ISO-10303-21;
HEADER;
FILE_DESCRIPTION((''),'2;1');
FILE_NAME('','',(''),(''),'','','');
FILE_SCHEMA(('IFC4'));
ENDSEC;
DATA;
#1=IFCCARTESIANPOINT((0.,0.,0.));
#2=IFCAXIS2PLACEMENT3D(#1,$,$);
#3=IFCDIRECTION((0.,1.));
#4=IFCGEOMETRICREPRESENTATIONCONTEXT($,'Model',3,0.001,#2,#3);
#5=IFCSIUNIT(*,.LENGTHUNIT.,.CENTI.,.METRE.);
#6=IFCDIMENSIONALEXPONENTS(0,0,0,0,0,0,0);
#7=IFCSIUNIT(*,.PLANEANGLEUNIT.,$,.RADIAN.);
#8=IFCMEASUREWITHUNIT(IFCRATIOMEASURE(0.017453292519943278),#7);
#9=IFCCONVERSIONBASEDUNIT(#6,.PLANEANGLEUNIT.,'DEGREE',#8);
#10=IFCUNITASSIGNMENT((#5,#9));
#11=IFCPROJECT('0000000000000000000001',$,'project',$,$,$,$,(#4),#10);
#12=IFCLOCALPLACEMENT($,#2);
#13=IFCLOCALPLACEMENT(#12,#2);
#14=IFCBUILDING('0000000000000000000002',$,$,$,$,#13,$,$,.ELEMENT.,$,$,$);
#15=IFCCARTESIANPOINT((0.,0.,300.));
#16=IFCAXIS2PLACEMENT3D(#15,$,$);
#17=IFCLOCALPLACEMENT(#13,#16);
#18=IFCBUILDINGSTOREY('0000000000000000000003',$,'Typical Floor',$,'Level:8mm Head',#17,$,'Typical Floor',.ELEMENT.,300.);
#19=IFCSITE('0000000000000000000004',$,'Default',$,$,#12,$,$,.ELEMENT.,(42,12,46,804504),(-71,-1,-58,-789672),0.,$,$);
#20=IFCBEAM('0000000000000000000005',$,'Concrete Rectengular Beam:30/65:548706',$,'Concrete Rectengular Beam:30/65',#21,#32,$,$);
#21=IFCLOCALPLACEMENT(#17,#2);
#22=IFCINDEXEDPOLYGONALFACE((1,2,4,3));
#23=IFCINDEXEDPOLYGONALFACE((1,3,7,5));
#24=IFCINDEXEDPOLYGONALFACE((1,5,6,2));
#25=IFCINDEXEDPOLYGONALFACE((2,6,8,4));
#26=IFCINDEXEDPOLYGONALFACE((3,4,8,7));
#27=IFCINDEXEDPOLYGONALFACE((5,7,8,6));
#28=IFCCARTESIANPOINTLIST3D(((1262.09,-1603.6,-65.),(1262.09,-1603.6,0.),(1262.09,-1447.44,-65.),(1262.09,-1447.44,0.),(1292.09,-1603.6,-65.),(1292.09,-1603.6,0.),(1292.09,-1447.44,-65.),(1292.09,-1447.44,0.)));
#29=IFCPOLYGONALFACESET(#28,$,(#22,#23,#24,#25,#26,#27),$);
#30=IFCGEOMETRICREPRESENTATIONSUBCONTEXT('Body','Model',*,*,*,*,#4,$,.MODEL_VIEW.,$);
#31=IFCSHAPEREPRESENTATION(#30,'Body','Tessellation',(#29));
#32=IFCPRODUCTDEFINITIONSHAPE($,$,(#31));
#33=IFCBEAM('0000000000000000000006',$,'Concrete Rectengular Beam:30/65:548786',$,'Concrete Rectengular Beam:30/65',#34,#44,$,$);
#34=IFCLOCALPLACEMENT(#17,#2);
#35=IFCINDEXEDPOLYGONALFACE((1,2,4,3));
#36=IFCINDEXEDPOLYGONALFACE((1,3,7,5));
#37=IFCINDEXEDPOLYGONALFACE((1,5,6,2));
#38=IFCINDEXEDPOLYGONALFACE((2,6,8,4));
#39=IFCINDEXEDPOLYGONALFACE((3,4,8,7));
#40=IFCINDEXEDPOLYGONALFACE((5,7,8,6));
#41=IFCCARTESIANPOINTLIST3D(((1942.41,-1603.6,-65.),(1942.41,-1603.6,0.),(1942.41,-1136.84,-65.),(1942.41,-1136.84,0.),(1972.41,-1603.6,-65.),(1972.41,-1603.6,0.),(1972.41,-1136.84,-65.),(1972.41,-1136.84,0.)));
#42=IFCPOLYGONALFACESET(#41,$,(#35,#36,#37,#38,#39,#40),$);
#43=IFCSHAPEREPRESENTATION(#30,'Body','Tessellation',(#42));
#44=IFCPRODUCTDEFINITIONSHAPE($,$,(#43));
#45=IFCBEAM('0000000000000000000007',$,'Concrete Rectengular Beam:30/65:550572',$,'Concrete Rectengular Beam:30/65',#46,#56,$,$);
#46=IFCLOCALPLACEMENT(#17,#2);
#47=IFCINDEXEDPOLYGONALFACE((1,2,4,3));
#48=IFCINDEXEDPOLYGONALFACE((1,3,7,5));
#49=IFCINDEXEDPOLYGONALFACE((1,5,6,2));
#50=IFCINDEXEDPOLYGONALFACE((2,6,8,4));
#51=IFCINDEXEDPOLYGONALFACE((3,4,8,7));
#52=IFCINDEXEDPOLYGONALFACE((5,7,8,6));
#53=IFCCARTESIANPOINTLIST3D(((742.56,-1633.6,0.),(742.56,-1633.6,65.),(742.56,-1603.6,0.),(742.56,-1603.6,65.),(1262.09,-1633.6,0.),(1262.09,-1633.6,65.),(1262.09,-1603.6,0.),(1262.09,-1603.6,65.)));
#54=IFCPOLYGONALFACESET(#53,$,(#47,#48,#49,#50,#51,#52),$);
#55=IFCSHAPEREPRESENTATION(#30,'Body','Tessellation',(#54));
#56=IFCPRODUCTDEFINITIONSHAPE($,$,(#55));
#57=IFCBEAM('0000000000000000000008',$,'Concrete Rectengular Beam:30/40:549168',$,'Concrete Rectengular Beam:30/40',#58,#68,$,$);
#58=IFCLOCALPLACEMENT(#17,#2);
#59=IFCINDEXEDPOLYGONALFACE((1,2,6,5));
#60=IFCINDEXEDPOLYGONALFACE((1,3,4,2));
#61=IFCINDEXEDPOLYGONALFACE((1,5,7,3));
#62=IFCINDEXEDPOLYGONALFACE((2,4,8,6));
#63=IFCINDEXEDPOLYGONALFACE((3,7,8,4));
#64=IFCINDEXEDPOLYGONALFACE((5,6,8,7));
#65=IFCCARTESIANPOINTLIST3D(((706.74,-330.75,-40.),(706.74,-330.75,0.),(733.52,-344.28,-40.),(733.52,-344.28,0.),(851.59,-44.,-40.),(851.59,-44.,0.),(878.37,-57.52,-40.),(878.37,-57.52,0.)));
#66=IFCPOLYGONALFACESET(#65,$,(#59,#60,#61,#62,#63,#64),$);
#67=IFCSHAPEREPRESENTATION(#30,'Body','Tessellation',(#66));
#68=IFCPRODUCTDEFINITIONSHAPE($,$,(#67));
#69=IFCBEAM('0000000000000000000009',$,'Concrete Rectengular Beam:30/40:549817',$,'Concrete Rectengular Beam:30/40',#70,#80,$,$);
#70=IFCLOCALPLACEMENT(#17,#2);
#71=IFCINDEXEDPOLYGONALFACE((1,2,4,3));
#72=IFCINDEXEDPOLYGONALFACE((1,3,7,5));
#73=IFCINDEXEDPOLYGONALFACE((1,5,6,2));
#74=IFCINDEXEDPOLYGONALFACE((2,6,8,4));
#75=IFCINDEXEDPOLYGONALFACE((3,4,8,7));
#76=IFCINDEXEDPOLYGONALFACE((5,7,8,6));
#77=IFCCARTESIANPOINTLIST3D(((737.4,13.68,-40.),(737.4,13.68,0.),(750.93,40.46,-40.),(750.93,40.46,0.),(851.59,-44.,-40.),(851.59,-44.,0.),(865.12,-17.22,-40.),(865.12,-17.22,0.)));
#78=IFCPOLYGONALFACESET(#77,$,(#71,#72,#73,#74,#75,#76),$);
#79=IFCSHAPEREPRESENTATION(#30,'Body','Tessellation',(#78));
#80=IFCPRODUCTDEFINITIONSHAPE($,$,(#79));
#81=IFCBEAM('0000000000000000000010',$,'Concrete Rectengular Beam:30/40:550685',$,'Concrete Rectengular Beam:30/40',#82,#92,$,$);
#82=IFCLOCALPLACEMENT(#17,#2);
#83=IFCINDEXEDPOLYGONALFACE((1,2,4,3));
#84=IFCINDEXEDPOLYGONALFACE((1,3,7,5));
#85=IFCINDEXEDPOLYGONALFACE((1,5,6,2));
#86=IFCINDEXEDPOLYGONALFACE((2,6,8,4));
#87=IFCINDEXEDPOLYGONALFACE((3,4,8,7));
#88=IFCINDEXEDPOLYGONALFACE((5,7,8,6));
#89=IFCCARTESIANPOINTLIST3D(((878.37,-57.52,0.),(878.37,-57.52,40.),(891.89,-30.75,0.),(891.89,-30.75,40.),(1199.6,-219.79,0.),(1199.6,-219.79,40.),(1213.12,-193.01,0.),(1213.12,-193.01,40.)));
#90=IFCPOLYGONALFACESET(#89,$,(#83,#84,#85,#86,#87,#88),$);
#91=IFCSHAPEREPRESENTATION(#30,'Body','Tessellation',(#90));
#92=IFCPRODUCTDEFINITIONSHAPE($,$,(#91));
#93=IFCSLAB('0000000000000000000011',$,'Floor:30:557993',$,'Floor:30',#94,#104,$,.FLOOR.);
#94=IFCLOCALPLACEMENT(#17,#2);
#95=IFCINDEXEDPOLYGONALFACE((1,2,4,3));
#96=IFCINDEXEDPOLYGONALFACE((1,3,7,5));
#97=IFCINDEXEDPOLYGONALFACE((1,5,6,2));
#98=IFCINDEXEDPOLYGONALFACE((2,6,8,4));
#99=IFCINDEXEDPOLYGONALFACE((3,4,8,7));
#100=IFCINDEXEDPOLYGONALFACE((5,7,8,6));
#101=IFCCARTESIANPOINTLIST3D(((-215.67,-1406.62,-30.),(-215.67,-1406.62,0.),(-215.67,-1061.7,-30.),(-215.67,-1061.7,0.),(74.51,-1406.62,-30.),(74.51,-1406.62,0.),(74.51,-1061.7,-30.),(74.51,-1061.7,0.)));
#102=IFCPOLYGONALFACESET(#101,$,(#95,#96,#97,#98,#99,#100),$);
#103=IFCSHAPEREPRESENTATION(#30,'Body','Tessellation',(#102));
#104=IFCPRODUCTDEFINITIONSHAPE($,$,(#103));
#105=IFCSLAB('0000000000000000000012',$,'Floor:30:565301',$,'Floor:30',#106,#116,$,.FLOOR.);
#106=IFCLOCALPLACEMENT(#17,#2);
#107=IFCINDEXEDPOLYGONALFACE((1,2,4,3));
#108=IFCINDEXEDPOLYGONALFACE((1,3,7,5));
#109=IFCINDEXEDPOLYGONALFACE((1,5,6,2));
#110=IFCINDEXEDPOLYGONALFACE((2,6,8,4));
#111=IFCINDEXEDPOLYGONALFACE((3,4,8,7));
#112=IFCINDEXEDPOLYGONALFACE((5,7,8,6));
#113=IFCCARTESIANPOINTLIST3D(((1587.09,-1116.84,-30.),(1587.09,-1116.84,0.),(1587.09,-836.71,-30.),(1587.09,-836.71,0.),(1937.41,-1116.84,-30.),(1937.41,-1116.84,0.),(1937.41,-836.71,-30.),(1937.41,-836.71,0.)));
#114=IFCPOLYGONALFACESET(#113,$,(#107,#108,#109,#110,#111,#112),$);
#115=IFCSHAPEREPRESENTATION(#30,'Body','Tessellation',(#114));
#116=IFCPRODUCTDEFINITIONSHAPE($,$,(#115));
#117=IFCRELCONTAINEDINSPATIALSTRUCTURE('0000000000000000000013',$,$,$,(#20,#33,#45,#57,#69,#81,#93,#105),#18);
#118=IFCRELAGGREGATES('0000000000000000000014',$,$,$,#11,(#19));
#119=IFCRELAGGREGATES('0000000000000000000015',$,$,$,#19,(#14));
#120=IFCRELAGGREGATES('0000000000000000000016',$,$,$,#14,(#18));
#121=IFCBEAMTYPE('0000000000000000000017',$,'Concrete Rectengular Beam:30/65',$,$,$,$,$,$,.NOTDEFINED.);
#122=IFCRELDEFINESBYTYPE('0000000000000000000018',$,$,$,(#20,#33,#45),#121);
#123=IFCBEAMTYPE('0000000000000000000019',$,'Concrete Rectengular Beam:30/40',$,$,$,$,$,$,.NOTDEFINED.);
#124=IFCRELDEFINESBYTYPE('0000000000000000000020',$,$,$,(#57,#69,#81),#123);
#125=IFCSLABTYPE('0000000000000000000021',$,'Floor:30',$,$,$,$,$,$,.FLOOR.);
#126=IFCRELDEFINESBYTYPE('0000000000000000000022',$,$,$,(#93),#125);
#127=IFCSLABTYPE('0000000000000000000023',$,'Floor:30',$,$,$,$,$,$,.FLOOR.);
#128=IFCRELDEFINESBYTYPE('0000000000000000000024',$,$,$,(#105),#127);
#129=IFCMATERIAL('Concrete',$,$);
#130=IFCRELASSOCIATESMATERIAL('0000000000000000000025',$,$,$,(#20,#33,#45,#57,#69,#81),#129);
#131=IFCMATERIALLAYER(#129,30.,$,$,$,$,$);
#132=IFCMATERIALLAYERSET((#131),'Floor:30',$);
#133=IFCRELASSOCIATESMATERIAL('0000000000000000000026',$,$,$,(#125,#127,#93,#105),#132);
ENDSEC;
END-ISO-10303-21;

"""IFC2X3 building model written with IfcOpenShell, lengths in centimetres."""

from ifc_helpers import new_model, entity, si_unit, converted_unit, direction, frame, frame_2d, origin, origin_2d_with_axis, place, context, subcontext, project, spatial, rectangle, extrude, material, layer, layer_set, layer_usage, type_object, element, save


model = new_model("IFC2X3")

# Units and contexts
model_context = context("Model", 3, precision=0.001, world=origin(), true_north=direction((0.0, 1.0)))
body_context = subcontext(model_context, "Body", "Model", "MODEL_VIEW")
ifc_project = project(units=[si_unit("LENGTHUNIT", "METRE", prefix="CENTI"), converted_unit("PLANEANGLEUNIT", "DEGREE", entity("IfcRatioMeasure", 0.017453292519943278), si_unit("PLANEANGLEUNIT", "RADIAN"), dimensions=[0, 0, 0, 0, 0, 0, 0])], contexts=[model_context])

# Site, building, storey
site_placement = place(None, origin())
site = spatial("IfcSite", under=ifc_project, at=site_placement, Name="Default", CompositionType="ELEMENT", RefLatitude=(42, 12, 46, 804504), RefLongitude=(-71, -1, -58, -789672), RefElevation=0.0)
building_placement = place(site_placement, origin())
building = spatial("IfcBuilding", under=site, at=building_placement, CompositionType="ELEMENT")
storey_placement = place(building_placement, frame((0.0, 0.0, 300.0)))
storey = spatial("IfcBuildingStorey", under=building, at=storey_placement, Name="Typical Floor", ObjectType="Level:8mm Head", LongName="Typical Floor", CompositionType="ELEMENT", Elevation=300.0)

# Beams
ifc_material = material(Name="Concrete")
beam_type_1 = type_object("IfcBeamType", Name="Concrete Rectengular Beam:30/65", PredefinedType="NOTDEFINED")
beam_1_placement = place(storey_placement, frame((1277.09, -1618.6, 0.0), z_axis=(0.0, 0.0, 1.0), x_axis=(0.0, 1.0, 0.0)))
element("IfcBeam", 1, at=beam_1_placement, inside=storey, type_object=beam_type_1, material=ifc_material, Name="Concrete Rectengular Beam:30/65:548706", ObjectType="Concrete Rectengular Beam:30/65", context=body_context, shape_type="SweptSolid", body=[
    extrude(rectangle(XDim=65.0, YDim=30.0, at=frame_2d((0.0, 0.0), x_axis=(1.0, 0.0))), frame((15.0, 0.0, -32.5), z_axis=(1.0, 0.0, 0.0), x_axis=(0.0, 0.0, -1.0)), (0.0, 0.0, 1.0), 156.15),
])
beam_2_placement = place(storey_placement, frame((1957.41, -1618.6, 0.0), z_axis=(0.0, 0.0, 1.0), x_axis=(0.0, 1.0, 0.0)))
element("IfcBeam", 2, at=beam_2_placement, inside=storey, type_object=beam_type_1, material=ifc_material, Name="Concrete Rectengular Beam:30/65:548786", ObjectType="Concrete Rectengular Beam:30/65", context=body_context, shape_type="SweptSolid", body=[
    extrude(rectangle(XDim=65.0, YDim=30.0, at=frame_2d((0.0, 0.0), x_axis=(1.0, 0.0))), frame((15.0, 0.0, -32.5), z_axis=(1.0, 0.0, 0.0), x_axis=(0.0, 0.0, -1.0)), (0.0, 0.0, 1.0), 466.76),
])
beam_3_placement = place(storey_placement, frame((742.56, -1618.6, 0.0)))
element("IfcBeam", 3, at=beam_3_placement, inside=storey, type_object=beam_type_1, material=ifc_material, Name="Concrete Rectengular Beam:30/65:550572", ObjectType="Concrete Rectengular Beam:30/65", context=body_context, shape_type="SweptSolid", body=[
    extrude(rectangle(XDim=65.0, YDim=30.0, at=frame_2d((0.0, 0.0), x_axis=(1.0, 0.0))), frame((0.0, 0.0, 32.5), z_axis=(1.0, 0.0, 0.0), x_axis=(0.0, 0.0, -1.0)), (0.0, 0.0, 1.0), 519.53),
])
beam_type_2 = type_object("IfcBeamType", Name="Concrete Rectengular Beam:30/40", PredefinedType="NOTDEFINED")
beam_4_placement = place(storey_placement, frame((864.98, -50.76, 0.0), z_axis=(0.0, 0.0, 1.0), x_axis=(-0.450875, -0.892587, 0.0)))
element("IfcBeam", 4, at=beam_4_placement, inside=storey, type_object=beam_type_2, material=ifc_material, Name="Concrete Rectengular Beam:30/40:549168", ObjectType="Concrete Rectengular Beam:30/40", context=body_context, shape_type="SweptSolid", body=[
    extrude(rectangle(XDim=40.0, YDim=30.0, at=origin_2d_with_axis()), frame((0.0, 0.0, -20.0), z_axis=(1.0, 0.0, 0.0), x_axis=(0.0, 0.0, -1.0)), (0.0, 0.0, 1.0), 321.26),
])
beam_5_placement = place(storey_placement, frame((871.74, -37.37, 0.0), z_axis=(0.0, 0.0, 1.0), x_axis=(-0.892587, 0.450875, 0.0)))
element("IfcBeam", 5, at=beam_5_placement, inside=storey, type_object=beam_type_2, material=ifc_material, Name="Concrete Rectengular Beam:30/40:549817", ObjectType="Concrete Rectengular Beam:30/40", context=body_context, shape_type="SweptSolid", body=[
    extrude(rectangle(XDim=40.0, YDim=30.0, at=frame_2d((0.0, 0.0), x_axis=(1.0, 0.0))), frame((15.0, 0.0, -20.0), z_axis=(1.0, 0.0, 0.0), x_axis=(0.0, 0.0, -1.0)), (0.0, 0.0, 1.0), 127.93),
])
beam_6_placement = place(storey_placement, frame((1206.36, -206.4, 0.0), z_axis=(0.0, 0.0, 1.0), x_axis=(-0.892587, 0.450875, 0.0)))
element("IfcBeam", 6, at=beam_6_placement, inside=storey, type_object=beam_type_2, material=ifc_material, Name="Concrete Rectengular Beam:30/40:550685", ObjectType="Concrete Rectengular Beam:30/40", context=body_context, shape_type="SweptSolid", body=[
    extrude(rectangle(XDim=40.0, YDim=30.0, at=frame_2d((0.0, 0.0), x_axis=(1.0, 0.0))), frame((0.0, 0.0, 20.0), z_axis=(1.0, 0.0, 0.0), x_axis=(0.0, 0.0, -1.0)), (0.0, 0.0, 1.0), 359.88),
])

# Slabs
ifc_layer = layer(ifc_material, 30.0)
ifc_layer_set = layer_set([ifc_layer], Name="Floor:30")
ifc_layer_usage_1 = layer_usage(ifc_layer_set, "AXIS3", "POSITIVE", 0.0)
slab_type_1 = type_object("IfcSlabType", Name="Floor:30", PredefinedType="FLOOR", material=ifc_layer_set)
slab_1_placement = place(storey_placement, origin())
element("IfcSlab", 7, at=slab_1_placement, inside=storey, type_object=slab_type_1, material=ifc_layer_usage_1, Name="Floor:30:557993", ObjectType="Floor:30", PredefinedType="FLOOR", context=body_context, shape_type="SweptSolid", body=[
    extrude(rectangle(XDim=344.92, YDim=290.18, at=frame_2d((0.0, 0.0), x_axis=(1.0, 0.0))), frame((-70.58, -1234.16, 0.0), z_axis=(0.0, 0.0, -1.0), x_axis=(0.0, 1.0, 0.0)), (0.0, 0.0, 1.0), 30.0),
])
ifc_layer_usage_2 = layer_usage(ifc_layer_set, "AXIS3", "POSITIVE", 0.0)
slab_type_2 = type_object("IfcSlabType", Name="Floor:30", PredefinedType="FLOOR", material=ifc_layer_set)
slab_2_placement = place(storey_placement, origin())
element("IfcSlab", 8, at=slab_2_placement, inside=storey, type_object=slab_type_2, material=ifc_layer_usage_2, Name="Floor:30:565301", ObjectType="Floor:30", PredefinedType="FLOOR", context=body_context, shape_type="SweptSolid", body=[
    extrude(rectangle(XDim=280.13, YDim=350.32, at=frame_2d((0.0, 0.0), x_axis=(1.0, 0.0))), frame((1762.25, -976.78, 0.0), z_axis=(0.0, 0.0, -1.0), x_axis=(0.0, 1.0, 0.0)), (0.0, 0.0, 1.0), 30.0),
])

save(model, "model.ifc")
